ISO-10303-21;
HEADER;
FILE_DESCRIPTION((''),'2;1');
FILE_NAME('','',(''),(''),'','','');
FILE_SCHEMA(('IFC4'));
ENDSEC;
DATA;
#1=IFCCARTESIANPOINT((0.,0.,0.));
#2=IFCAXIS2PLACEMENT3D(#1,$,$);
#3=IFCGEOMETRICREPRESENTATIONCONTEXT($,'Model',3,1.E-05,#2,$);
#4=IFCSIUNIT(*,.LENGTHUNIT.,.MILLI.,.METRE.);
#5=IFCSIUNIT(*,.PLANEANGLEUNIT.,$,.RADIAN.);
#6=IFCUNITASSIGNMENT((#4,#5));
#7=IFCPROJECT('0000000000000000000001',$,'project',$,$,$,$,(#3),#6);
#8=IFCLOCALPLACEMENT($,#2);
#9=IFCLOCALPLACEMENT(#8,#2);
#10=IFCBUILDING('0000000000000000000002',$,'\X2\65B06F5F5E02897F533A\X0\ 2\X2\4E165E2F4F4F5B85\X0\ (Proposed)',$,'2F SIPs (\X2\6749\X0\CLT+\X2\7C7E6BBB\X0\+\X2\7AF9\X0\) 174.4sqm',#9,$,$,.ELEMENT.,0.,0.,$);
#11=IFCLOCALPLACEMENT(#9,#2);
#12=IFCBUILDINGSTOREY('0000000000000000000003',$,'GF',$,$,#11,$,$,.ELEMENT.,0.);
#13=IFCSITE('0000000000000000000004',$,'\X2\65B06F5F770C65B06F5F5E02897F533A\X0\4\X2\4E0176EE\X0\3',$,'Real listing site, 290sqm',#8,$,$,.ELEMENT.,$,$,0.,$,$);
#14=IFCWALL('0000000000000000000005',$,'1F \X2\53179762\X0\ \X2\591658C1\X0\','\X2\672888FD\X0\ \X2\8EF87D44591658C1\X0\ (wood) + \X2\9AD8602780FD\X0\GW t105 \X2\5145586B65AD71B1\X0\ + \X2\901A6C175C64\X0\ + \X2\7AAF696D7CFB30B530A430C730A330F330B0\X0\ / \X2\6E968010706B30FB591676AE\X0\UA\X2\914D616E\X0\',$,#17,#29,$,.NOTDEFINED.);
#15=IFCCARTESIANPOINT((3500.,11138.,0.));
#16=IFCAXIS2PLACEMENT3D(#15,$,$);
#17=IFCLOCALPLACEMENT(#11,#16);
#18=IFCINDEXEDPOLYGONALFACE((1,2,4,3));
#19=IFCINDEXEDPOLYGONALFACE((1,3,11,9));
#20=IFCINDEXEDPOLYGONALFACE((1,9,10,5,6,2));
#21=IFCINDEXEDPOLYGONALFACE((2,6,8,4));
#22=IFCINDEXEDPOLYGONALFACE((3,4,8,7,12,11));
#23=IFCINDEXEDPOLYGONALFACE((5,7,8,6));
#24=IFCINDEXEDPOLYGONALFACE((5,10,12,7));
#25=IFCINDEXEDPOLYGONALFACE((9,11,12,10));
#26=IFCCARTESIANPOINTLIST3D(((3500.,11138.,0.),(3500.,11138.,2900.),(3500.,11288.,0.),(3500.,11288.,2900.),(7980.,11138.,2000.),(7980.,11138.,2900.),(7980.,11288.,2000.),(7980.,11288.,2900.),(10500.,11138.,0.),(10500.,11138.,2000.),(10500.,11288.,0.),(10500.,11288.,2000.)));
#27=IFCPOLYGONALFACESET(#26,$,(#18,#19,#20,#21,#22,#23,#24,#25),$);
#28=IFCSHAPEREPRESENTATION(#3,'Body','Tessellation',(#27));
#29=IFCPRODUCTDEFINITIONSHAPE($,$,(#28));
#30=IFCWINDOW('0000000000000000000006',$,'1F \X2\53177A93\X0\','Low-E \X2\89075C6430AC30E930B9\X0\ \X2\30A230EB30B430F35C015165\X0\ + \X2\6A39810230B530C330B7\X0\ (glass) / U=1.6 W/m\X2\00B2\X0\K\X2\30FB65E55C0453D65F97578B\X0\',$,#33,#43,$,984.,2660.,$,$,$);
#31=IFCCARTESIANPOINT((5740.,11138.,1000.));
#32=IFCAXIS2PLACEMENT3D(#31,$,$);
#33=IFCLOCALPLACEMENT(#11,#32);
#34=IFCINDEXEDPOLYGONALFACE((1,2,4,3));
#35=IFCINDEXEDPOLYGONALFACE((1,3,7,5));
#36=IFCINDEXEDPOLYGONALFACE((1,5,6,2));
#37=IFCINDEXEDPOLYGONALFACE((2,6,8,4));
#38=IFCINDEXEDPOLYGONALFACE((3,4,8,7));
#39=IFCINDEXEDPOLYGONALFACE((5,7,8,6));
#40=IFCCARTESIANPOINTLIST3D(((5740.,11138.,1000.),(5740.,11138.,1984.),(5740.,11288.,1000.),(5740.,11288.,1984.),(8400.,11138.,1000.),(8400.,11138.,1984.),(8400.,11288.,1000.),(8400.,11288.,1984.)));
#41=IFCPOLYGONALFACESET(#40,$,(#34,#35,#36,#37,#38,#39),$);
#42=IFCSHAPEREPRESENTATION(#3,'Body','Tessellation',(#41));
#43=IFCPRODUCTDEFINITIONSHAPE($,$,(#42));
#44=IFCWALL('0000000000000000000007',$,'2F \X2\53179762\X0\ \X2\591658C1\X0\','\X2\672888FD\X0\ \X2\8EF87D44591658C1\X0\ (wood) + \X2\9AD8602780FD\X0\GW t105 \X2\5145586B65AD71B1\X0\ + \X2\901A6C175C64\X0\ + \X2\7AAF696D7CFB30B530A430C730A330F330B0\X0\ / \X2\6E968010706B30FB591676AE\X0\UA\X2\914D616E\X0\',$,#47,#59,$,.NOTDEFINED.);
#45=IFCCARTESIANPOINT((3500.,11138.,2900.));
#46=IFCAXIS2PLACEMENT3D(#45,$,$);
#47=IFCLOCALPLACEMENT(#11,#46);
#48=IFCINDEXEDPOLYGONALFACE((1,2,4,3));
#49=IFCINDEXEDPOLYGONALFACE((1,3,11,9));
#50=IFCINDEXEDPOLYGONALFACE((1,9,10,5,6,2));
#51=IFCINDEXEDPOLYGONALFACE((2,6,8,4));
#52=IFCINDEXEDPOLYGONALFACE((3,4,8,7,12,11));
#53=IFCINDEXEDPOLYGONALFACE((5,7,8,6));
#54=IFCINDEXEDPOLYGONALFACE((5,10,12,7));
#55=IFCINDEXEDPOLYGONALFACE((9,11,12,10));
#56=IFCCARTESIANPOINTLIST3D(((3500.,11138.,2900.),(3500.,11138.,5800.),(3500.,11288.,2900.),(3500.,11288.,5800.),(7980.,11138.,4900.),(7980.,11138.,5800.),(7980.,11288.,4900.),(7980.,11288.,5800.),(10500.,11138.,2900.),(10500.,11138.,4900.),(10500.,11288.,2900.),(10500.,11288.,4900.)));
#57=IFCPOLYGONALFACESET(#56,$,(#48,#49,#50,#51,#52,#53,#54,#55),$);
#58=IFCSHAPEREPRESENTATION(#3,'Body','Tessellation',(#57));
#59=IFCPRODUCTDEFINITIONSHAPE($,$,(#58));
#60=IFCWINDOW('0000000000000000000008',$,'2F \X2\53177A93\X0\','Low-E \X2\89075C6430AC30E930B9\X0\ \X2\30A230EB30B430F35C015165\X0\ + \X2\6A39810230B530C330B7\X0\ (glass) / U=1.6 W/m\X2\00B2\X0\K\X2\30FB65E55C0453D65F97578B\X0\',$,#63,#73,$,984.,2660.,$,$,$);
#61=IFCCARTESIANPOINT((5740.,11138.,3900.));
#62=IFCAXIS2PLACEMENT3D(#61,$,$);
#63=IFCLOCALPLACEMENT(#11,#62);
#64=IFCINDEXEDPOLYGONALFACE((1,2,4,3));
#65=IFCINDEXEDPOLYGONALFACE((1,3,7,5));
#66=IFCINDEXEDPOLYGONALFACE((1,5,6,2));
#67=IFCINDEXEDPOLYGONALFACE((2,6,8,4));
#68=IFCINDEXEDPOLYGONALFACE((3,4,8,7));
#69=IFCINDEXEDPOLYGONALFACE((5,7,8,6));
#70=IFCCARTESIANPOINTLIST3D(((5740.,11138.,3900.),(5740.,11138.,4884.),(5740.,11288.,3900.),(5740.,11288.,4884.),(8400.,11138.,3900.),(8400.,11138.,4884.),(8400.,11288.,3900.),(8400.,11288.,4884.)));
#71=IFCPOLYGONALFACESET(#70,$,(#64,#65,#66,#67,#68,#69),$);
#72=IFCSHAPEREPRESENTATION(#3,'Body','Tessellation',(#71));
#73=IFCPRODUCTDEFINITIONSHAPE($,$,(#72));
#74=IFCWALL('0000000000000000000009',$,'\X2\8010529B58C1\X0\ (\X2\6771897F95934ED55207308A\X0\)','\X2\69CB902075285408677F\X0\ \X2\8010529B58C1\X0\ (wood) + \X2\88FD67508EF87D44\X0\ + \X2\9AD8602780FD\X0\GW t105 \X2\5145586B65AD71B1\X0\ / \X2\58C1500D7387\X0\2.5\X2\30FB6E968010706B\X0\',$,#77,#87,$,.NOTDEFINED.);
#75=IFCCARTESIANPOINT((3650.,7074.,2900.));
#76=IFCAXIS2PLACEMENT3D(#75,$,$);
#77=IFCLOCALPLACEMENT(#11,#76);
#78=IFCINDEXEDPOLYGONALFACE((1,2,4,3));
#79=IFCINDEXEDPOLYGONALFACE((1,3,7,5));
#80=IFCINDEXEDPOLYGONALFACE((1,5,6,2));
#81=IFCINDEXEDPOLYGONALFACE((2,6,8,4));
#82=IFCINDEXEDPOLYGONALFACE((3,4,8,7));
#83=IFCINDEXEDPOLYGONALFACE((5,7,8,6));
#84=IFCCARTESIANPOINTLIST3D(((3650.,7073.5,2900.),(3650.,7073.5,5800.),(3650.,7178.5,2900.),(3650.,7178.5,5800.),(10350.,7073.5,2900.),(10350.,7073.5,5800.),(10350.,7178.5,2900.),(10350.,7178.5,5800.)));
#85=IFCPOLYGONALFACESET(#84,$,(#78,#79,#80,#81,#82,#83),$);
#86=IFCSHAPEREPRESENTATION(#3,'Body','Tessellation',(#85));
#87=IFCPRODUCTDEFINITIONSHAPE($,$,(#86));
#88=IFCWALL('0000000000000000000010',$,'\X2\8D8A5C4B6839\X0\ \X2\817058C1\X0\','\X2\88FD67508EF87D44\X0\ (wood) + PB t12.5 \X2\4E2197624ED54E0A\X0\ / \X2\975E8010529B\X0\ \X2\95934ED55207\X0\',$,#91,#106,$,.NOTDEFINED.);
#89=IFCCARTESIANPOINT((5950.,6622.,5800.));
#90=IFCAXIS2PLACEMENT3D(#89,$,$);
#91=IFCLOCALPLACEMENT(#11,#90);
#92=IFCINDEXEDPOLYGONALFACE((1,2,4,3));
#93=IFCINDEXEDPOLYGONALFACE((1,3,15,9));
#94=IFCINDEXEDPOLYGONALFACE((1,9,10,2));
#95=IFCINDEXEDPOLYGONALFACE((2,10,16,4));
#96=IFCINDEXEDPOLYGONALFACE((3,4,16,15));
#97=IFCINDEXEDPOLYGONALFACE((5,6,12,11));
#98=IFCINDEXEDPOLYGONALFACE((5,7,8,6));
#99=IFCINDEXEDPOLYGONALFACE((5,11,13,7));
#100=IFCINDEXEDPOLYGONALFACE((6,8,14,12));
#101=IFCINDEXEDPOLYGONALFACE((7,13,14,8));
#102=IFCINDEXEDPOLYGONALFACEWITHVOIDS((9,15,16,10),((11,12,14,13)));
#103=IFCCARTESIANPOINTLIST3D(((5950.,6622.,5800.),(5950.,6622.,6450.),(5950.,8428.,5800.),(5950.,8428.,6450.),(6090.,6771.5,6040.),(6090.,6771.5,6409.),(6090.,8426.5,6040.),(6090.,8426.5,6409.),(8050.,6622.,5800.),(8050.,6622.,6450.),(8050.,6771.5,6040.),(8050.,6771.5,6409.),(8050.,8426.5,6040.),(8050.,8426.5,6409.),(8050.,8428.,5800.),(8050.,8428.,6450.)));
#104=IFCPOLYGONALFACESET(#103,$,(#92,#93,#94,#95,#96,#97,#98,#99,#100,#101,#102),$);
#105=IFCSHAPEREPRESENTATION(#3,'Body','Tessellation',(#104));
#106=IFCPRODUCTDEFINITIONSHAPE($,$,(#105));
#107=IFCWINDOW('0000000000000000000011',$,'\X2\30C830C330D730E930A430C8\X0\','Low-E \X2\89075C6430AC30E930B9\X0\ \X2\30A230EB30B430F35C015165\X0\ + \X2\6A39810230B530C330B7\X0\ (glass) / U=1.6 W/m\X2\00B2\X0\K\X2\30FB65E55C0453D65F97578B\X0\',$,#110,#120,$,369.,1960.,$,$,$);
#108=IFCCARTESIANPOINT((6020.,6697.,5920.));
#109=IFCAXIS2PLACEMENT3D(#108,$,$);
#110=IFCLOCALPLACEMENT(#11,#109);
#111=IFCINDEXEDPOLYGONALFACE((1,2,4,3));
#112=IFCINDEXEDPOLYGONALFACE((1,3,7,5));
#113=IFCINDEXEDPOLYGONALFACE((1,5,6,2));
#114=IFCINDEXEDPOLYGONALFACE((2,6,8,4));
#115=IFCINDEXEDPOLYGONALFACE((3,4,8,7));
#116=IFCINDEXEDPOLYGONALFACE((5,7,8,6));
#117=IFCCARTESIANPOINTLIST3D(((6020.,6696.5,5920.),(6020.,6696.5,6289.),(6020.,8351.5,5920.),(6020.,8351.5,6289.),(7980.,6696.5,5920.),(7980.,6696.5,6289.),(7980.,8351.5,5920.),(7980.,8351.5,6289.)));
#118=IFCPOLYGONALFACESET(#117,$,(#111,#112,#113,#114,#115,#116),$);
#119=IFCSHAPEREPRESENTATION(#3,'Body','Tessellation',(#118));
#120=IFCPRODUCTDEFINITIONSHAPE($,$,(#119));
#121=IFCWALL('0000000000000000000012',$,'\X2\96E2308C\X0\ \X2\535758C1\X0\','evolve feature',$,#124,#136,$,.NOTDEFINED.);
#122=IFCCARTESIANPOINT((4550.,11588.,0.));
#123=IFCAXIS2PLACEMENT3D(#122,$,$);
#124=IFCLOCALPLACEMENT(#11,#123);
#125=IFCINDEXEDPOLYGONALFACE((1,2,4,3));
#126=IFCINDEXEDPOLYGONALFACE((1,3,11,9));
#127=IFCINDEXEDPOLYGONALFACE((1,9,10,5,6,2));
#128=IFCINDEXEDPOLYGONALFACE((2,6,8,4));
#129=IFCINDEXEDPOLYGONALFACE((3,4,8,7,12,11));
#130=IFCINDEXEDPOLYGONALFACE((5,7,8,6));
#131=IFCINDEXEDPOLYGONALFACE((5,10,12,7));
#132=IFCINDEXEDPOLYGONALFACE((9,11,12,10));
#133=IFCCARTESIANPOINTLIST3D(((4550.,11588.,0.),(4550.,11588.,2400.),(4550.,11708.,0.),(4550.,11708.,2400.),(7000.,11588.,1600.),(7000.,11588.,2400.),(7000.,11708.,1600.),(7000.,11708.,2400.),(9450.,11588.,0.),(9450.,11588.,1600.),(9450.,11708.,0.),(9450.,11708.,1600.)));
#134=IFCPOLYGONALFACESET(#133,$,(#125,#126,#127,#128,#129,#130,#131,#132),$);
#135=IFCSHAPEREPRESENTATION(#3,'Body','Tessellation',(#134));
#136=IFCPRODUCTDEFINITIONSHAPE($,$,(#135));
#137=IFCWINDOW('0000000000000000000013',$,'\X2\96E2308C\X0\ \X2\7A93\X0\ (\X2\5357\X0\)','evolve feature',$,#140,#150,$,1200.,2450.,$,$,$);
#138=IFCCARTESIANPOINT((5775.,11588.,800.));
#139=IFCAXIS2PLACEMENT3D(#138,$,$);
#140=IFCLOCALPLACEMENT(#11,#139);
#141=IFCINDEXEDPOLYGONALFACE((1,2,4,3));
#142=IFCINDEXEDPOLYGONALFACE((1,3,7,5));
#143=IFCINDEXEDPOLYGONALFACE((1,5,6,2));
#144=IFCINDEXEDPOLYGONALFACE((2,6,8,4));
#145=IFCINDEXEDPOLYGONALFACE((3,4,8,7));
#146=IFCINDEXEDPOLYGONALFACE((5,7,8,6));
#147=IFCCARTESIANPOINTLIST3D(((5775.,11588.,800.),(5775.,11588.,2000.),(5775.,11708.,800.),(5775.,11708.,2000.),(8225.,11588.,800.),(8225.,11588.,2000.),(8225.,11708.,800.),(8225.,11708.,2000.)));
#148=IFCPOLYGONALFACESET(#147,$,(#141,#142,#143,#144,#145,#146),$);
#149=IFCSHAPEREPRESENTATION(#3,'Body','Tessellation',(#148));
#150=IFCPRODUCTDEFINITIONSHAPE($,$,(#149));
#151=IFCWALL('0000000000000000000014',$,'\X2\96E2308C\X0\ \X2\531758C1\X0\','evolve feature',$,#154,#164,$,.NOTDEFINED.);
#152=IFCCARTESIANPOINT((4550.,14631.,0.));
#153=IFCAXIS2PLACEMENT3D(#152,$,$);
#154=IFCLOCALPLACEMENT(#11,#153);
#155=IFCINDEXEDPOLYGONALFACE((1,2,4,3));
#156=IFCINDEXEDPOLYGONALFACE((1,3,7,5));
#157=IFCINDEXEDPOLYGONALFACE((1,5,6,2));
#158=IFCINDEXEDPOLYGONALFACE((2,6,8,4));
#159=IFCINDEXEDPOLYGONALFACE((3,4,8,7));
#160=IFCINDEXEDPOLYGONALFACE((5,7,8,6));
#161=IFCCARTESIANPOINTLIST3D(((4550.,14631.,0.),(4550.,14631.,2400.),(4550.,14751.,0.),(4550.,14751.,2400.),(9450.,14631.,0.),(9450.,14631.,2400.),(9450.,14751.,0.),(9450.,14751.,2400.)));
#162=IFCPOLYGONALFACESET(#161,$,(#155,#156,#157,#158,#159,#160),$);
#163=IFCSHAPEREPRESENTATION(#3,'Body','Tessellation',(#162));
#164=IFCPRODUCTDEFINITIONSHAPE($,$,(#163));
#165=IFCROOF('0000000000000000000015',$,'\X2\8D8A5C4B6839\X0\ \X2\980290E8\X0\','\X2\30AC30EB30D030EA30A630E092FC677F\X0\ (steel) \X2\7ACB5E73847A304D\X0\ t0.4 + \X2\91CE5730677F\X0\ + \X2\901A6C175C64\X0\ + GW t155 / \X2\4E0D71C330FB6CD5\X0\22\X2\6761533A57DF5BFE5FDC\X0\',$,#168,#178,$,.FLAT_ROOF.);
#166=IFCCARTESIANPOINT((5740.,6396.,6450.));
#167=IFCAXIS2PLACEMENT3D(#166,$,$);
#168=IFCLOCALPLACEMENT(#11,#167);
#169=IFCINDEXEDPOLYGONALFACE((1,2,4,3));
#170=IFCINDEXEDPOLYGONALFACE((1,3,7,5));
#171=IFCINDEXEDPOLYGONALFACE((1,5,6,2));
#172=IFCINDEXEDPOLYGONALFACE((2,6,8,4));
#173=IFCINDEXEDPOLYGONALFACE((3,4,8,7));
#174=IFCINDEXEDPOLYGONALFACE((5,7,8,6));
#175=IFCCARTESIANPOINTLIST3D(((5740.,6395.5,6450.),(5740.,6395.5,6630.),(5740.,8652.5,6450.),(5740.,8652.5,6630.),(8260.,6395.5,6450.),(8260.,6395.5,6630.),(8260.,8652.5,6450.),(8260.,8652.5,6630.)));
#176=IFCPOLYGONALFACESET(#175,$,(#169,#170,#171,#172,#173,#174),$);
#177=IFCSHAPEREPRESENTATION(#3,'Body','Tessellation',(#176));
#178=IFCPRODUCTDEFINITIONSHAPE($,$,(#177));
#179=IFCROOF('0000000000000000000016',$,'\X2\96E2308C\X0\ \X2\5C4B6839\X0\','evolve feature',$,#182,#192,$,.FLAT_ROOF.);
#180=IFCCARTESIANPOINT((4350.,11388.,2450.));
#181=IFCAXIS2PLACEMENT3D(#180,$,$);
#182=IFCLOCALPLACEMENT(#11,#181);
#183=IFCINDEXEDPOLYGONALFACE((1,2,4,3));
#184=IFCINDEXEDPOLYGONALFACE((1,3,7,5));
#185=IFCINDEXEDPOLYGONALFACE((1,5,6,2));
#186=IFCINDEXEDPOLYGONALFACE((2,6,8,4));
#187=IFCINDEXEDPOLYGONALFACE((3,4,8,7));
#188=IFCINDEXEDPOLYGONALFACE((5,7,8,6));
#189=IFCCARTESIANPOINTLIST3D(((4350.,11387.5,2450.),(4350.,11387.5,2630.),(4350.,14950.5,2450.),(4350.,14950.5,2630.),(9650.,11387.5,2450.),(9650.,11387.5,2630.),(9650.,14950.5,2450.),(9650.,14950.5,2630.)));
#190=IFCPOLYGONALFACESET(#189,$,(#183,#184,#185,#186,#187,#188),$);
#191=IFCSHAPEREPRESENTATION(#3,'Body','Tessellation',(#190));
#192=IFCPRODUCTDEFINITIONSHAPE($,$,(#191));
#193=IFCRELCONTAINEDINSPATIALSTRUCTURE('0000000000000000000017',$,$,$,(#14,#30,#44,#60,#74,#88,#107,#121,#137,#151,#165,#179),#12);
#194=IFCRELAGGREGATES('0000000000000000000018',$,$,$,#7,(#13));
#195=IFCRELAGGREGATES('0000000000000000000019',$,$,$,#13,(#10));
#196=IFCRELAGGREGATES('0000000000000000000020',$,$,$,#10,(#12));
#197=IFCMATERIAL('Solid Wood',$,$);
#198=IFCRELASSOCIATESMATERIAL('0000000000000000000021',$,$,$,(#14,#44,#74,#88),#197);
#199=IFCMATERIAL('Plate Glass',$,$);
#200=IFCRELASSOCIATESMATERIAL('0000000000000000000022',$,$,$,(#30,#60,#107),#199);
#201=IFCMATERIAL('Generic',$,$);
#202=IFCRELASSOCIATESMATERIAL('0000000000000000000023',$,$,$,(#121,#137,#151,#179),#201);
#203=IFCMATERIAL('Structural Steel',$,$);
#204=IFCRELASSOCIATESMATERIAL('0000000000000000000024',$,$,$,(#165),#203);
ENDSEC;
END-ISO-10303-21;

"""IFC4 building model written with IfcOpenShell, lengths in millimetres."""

from ifc_helpers import new_model, si_unit, frame, frame_2d, origin, place, context, project, spatial, rectangle, extrude, material, element, fill, save


model = new_model("IFC4")

# Units and contexts
model_context = context("Model", 3, precision=1e-05, world=origin())
ifc_project = project(units=[si_unit("LENGTHUNIT", "METRE", prefix="MILLI"), si_unit("PLANEANGLEUNIT", "RADIAN")], contexts=[model_context])

# Site, building, storey
site_placement = place(None, origin())
site = spatial("IfcSite", under=ifc_project, at=site_placement, Name="新潟県新潟市西区4丁目3", ObjectType="Real listing site, 290sqm", CompositionType="ELEMENT", RefElevation=0.0)
building_placement = place(site_placement, origin())
building = spatial("IfcBuilding", under=site, at=building_placement, Name="新潟市西区 2世帯住宅 (Proposed)", ObjectType="2F SIPs (杉CLT+籾殻+竹) 174.4sqm", CompositionType="ELEMENT", ElevationOfRefHeight=0.0, ElevationOfTerrain=0.0)
storey_placement = place(building_placement, origin())
storey = spatial("IfcBuildingStorey", under=building, at=storey_placement, Name="GF", CompositionType="ELEMENT", Elevation=0.0)

# Shared definitions
ifc_material_1 = material(Name="Generic")

# Wall, opening, window
ifc_material_2 = material(Name="Solid Wood")
wall_1_placement = place(storey_placement, frame((3500.0, 11138.0, 0.0)))
wall_1 = element("IfcWall", 1, at=wall_1_placement, inside=storey, material=ifc_material_2, Name="1F 北面 外壁", Description="木製 軸組外壁 (wood) + 高性能GW t105 充填断熱 + 通気層 + 窯業系サイディング / 準耐火・外皮UA配慮", PredefinedType="NOTDEFINED", context=model_context, shape_type="SweptSolid", body=[
    extrude(rectangle(XDim=7000.0, YDim=150.0, at=frame_2d((3500.0, 75.0))), frame((3500.0, 11138.0, 0.0)), (0.0, 0.0, 1.0), 2900.0),
])
opening_1_placement = place(storey_placement, frame((5740.0, 11138.0, 1000.0)))
opening_1 = element("IfcOpeningElement", 2, at=opening_1_placement, cuts=wall_1, PredefinedType="NOTDEFINED", context=model_context, shape_type="SweptSolid", body=[
    extrude(rectangle(XDim=2660.0, YDim=150.0, at=frame_2d((1330.0, 75.0))), frame((5740.0, 11138.0, 1000.0)), (0.0, 0.0, 1.0), 984.0),
])
ifc_material_3 = material(Name="Plate Glass")
window_1_placement = place(storey_placement, frame((5740.0, 11138.0, 1000.0)))
window_1 = element("IfcWindow", 3, at=window_1_placement, inside=storey, material=ifc_material_3, Name="1F 北窓", Description="Low-E 複層ガラス アルゴン封入 + 樹脂サッシ (glass) / U=1.6 W/m²K・日射取得型", OverallHeight=984.0, OverallWidth=2660.0, context=model_context, shape_type="SweptSolid", body=[
    extrude(rectangle(XDim=2660.0, YDim=150.0, at=frame_2d((1330.0, 75.0))), frame((5740.0, 11138.0, 1000.0)), (0.0, 0.0, 1.0), 984.0),
])
fill(opening_1, window_1)

# Wall, opening, window
wall_2_placement = place(storey_placement, frame((3500.0, 11138.0, 2900.0)))
wall_2 = element("IfcWall", 4, at=wall_2_placement, inside=storey, material=ifc_material_2, Name="2F 北面 外壁", Description="木製 軸組外壁 (wood) + 高性能GW t105 充填断熱 + 通気層 + 窯業系サイディング / 準耐火・外皮UA配慮", PredefinedType="NOTDEFINED", context=model_context, shape_type="SweptSolid", body=[
    extrude(rectangle(XDim=7000.0, YDim=150.0, at=frame_2d((3500.0, 75.0))), frame((3500.0, 11138.0, 2900.0)), (0.0, 0.0, 1.0), 2900.0),
])
opening_2_placement = place(storey_placement, frame((5740.0, 11138.0, 3900.0)))
opening_2 = element("IfcOpeningElement", 5, at=opening_2_placement, cuts=wall_2, PredefinedType="NOTDEFINED", context=model_context, shape_type="SweptSolid", body=[
    extrude(rectangle(XDim=2660.0, YDim=150.0, at=frame_2d((1330.0, 75.0))), frame((5740.0, 11138.0, 3900.0)), (0.0, 0.0, 1.0), 984.0),
])
window_2_placement = place(storey_placement, frame((5740.0, 11138.0, 3900.0)))
window_2 = element("IfcWindow", 6, at=window_2_placement, inside=storey, material=ifc_material_3, Name="2F 北窓", Description="Low-E 複層ガラス アルゴン封入 + 樹脂サッシ (glass) / U=1.6 W/m²K・日射取得型", OverallHeight=984.0, OverallWidth=2660.0, context=model_context, shape_type="SweptSolid", body=[
    extrude(rectangle(XDim=2660.0, YDim=150.0, at=frame_2d((1330.0, 75.0))), frame((5740.0, 11138.0, 3900.0)), (0.0, 0.0, 1.0), 984.0),
])
fill(opening_2, window_2)

# Wall
wall_3_placement = place(storey_placement, frame((3650.0, 7074.0, 2900.0)))
element("IfcWall", 7, at=wall_3_placement, inside=storey, material=ifc_material_2, Name="耐力壁 (東西間仕切り)", Description="構造用合板 耐力壁 (wood) + 製材軸組 + 高性能GW t105 充填断熱 / 壁倍率2.5・準耐火", PredefinedType="NOTDEFINED", context=model_context, shape_type="SweptSolid", body=[
    extrude(rectangle(XDim=6700.0, YDim=105.0, at=frame_2d((3350.0, 52.0))), frame((3650.0, 7074.0, 2900.0)), (0.0, 0.0, 1.0), 2900.0),
])

# Walls, openings, windows
wall_4_placement = place(storey_placement, frame((5950.0, 6622.0, 5800.0)))
wall_4 = element("IfcWall", 8, at=wall_4_placement, inside=storey, material=ifc_material_2, Name="越屋根 腰壁", Description="製材軸組 (wood) + PB t12.5 両面仕上 / 非耐力 間仕切", PredefinedType="NOTDEFINED", context=model_context, shape_type="SweptSolid", body=[
    extrude(rectangle(XDim=2100.0, YDim=1806.0, at=frame_2d((1050.0, 903.0))), frame((5950.0, 6622.0, 5800.0)), (0.0, 0.0, 1.0), 650.0),
])
opening_3_placement = place(storey_placement, frame((6020.0, 6697.0, 5920.0)))
opening_3 = element("IfcOpeningElement", 9, at=opening_3_placement, cuts=wall_4, PredefinedType="NOTDEFINED", context=model_context, shape_type="SweptSolid", body=[
    extrude(rectangle(XDim=1960.0, YDim=1655.0, at=frame_2d((980.0, 827.0))), frame((6020.0, 6697.0, 5920.0)), (0.0, 0.0, 1.0), 369.0),
])
window_3_placement = place(storey_placement, frame((6020.0, 6697.0, 5920.0)))
window_3 = element("IfcWindow", 10, at=window_3_placement, inside=storey, material=ifc_material_3, Name="トップライト", Description="Low-E 複層ガラス アルゴン封入 + 樹脂サッシ (glass) / U=1.6 W/m²K・日射取得型", OverallHeight=369.0, OverallWidth=1960.0, context=model_context, shape_type="SweptSolid", body=[
    extrude(rectangle(XDim=1960.0, YDim=1655.0, at=frame_2d((980.0, 827.0))), frame((6020.0, 6697.0, 5920.0)), (0.0, 0.0, 1.0), 369.0),
])
fill(opening_3, window_3)
wall_5_placement = place(storey_placement, frame((4550.0, 11588.0, 0.0)))
wall_5 = element("IfcWall", 11, at=wall_5_placement, inside=storey, material=ifc_material_1, Name="離れ 南壁", Description="evolve feature", PredefinedType="NOTDEFINED", context=model_context, shape_type="SweptSolid", body=[
    extrude(rectangle(XDim=4900.0, YDim=120.0, at=frame_2d((2450.0, 60.0))), frame((4550.0, 11588.0, 0.0)), (0.0, 0.0, 1.0), 2400.0),
])
opening_4_placement = place(storey_placement, frame((5775.0, 11588.0, 800.0)))
opening_4 = element("IfcOpeningElement", 12, at=opening_4_placement, cuts=wall_5, PredefinedType="NOTDEFINED", context=model_context, shape_type="SweptSolid", body=[
    extrude(rectangle(XDim=2450.0, YDim=120.0, at=frame_2d((1225.0, 60.0))), frame((5775.0, 11588.0, 800.0)), (0.0, 0.0, 1.0), 1200.0),
])
window_4_placement = place(storey_placement, frame((5775.0, 11588.0, 800.0)))
window_4 = element("IfcWindow", 13, at=window_4_placement, inside=storey, material=ifc_material_1, Name="離れ 窓 (南)", Description="evolve feature", OverallHeight=1200.0, OverallWidth=2450.0, context=model_context, shape_type="SweptSolid", body=[
    extrude(rectangle(XDim=2450.0, YDim=120.0, at=frame_2d((1225.0, 60.0))), frame((5775.0, 11588.0, 800.0)), (0.0, 0.0, 1.0), 1200.0),
])
fill(opening_4, window_4)

# Wall
wall_6_placement = place(storey_placement, frame((4550.0, 14631.0, 0.0)))
element("IfcWall", 14, at=wall_6_placement, inside=storey, material=ifc_material_1, Name="離れ 北壁", Description="evolve feature", PredefinedType="NOTDEFINED", context=model_context, shape_type="SweptSolid", body=[
    extrude(rectangle(XDim=4900.0, YDim=120.0, at=frame_2d((2450.0, 60.0))), frame((4550.0, 14631.0, 0.0)), (0.0, 0.0, 1.0), 2400.0),
])

# Roofs
ifc_material_4 = material(Name="Structural Steel")
roof_1_placement = place(storey_placement, frame((5740.0, 6396.0, 6450.0)))
element("IfcRoof", 15, at=roof_1_placement, inside=storey, material=ifc_material_4, Name="越屋根 頂部", Description="ガルバリウム鋼板 (steel) 立平葺き t0.4 + 野地板 + 通気層 + GW t155 / 不燃・法22条区域対応", PredefinedType="FLAT_ROOF", context=model_context, shape_type="SweptSolid", body=[
    extrude(rectangle(XDim=2520.0, YDim=2257.0, at=frame_2d((1260.0, 1128.0))), frame((5740.0, 6396.0, 6450.0)), (0.0, 0.0, 1.0), 180.0),
])
roof_2_placement = place(storey_placement, frame((4350.0, 11388.0, 2450.0)))
element("IfcRoof", 16, at=roof_2_placement, inside=storey, material=ifc_material_1, Name="離れ 屋根", Description="evolve feature", PredefinedType="FLAT_ROOF", context=model_context, shape_type="SweptSolid", body=[
    extrude(rectangle(XDim=5300.0, YDim=3563.0, at=frame_2d((2650.0, 1781.0))), frame((4350.0, 11388.0, 2450.0)), (0.0, 0.0, 1.0), 180.0),
])

save(model, "model.ifc")
